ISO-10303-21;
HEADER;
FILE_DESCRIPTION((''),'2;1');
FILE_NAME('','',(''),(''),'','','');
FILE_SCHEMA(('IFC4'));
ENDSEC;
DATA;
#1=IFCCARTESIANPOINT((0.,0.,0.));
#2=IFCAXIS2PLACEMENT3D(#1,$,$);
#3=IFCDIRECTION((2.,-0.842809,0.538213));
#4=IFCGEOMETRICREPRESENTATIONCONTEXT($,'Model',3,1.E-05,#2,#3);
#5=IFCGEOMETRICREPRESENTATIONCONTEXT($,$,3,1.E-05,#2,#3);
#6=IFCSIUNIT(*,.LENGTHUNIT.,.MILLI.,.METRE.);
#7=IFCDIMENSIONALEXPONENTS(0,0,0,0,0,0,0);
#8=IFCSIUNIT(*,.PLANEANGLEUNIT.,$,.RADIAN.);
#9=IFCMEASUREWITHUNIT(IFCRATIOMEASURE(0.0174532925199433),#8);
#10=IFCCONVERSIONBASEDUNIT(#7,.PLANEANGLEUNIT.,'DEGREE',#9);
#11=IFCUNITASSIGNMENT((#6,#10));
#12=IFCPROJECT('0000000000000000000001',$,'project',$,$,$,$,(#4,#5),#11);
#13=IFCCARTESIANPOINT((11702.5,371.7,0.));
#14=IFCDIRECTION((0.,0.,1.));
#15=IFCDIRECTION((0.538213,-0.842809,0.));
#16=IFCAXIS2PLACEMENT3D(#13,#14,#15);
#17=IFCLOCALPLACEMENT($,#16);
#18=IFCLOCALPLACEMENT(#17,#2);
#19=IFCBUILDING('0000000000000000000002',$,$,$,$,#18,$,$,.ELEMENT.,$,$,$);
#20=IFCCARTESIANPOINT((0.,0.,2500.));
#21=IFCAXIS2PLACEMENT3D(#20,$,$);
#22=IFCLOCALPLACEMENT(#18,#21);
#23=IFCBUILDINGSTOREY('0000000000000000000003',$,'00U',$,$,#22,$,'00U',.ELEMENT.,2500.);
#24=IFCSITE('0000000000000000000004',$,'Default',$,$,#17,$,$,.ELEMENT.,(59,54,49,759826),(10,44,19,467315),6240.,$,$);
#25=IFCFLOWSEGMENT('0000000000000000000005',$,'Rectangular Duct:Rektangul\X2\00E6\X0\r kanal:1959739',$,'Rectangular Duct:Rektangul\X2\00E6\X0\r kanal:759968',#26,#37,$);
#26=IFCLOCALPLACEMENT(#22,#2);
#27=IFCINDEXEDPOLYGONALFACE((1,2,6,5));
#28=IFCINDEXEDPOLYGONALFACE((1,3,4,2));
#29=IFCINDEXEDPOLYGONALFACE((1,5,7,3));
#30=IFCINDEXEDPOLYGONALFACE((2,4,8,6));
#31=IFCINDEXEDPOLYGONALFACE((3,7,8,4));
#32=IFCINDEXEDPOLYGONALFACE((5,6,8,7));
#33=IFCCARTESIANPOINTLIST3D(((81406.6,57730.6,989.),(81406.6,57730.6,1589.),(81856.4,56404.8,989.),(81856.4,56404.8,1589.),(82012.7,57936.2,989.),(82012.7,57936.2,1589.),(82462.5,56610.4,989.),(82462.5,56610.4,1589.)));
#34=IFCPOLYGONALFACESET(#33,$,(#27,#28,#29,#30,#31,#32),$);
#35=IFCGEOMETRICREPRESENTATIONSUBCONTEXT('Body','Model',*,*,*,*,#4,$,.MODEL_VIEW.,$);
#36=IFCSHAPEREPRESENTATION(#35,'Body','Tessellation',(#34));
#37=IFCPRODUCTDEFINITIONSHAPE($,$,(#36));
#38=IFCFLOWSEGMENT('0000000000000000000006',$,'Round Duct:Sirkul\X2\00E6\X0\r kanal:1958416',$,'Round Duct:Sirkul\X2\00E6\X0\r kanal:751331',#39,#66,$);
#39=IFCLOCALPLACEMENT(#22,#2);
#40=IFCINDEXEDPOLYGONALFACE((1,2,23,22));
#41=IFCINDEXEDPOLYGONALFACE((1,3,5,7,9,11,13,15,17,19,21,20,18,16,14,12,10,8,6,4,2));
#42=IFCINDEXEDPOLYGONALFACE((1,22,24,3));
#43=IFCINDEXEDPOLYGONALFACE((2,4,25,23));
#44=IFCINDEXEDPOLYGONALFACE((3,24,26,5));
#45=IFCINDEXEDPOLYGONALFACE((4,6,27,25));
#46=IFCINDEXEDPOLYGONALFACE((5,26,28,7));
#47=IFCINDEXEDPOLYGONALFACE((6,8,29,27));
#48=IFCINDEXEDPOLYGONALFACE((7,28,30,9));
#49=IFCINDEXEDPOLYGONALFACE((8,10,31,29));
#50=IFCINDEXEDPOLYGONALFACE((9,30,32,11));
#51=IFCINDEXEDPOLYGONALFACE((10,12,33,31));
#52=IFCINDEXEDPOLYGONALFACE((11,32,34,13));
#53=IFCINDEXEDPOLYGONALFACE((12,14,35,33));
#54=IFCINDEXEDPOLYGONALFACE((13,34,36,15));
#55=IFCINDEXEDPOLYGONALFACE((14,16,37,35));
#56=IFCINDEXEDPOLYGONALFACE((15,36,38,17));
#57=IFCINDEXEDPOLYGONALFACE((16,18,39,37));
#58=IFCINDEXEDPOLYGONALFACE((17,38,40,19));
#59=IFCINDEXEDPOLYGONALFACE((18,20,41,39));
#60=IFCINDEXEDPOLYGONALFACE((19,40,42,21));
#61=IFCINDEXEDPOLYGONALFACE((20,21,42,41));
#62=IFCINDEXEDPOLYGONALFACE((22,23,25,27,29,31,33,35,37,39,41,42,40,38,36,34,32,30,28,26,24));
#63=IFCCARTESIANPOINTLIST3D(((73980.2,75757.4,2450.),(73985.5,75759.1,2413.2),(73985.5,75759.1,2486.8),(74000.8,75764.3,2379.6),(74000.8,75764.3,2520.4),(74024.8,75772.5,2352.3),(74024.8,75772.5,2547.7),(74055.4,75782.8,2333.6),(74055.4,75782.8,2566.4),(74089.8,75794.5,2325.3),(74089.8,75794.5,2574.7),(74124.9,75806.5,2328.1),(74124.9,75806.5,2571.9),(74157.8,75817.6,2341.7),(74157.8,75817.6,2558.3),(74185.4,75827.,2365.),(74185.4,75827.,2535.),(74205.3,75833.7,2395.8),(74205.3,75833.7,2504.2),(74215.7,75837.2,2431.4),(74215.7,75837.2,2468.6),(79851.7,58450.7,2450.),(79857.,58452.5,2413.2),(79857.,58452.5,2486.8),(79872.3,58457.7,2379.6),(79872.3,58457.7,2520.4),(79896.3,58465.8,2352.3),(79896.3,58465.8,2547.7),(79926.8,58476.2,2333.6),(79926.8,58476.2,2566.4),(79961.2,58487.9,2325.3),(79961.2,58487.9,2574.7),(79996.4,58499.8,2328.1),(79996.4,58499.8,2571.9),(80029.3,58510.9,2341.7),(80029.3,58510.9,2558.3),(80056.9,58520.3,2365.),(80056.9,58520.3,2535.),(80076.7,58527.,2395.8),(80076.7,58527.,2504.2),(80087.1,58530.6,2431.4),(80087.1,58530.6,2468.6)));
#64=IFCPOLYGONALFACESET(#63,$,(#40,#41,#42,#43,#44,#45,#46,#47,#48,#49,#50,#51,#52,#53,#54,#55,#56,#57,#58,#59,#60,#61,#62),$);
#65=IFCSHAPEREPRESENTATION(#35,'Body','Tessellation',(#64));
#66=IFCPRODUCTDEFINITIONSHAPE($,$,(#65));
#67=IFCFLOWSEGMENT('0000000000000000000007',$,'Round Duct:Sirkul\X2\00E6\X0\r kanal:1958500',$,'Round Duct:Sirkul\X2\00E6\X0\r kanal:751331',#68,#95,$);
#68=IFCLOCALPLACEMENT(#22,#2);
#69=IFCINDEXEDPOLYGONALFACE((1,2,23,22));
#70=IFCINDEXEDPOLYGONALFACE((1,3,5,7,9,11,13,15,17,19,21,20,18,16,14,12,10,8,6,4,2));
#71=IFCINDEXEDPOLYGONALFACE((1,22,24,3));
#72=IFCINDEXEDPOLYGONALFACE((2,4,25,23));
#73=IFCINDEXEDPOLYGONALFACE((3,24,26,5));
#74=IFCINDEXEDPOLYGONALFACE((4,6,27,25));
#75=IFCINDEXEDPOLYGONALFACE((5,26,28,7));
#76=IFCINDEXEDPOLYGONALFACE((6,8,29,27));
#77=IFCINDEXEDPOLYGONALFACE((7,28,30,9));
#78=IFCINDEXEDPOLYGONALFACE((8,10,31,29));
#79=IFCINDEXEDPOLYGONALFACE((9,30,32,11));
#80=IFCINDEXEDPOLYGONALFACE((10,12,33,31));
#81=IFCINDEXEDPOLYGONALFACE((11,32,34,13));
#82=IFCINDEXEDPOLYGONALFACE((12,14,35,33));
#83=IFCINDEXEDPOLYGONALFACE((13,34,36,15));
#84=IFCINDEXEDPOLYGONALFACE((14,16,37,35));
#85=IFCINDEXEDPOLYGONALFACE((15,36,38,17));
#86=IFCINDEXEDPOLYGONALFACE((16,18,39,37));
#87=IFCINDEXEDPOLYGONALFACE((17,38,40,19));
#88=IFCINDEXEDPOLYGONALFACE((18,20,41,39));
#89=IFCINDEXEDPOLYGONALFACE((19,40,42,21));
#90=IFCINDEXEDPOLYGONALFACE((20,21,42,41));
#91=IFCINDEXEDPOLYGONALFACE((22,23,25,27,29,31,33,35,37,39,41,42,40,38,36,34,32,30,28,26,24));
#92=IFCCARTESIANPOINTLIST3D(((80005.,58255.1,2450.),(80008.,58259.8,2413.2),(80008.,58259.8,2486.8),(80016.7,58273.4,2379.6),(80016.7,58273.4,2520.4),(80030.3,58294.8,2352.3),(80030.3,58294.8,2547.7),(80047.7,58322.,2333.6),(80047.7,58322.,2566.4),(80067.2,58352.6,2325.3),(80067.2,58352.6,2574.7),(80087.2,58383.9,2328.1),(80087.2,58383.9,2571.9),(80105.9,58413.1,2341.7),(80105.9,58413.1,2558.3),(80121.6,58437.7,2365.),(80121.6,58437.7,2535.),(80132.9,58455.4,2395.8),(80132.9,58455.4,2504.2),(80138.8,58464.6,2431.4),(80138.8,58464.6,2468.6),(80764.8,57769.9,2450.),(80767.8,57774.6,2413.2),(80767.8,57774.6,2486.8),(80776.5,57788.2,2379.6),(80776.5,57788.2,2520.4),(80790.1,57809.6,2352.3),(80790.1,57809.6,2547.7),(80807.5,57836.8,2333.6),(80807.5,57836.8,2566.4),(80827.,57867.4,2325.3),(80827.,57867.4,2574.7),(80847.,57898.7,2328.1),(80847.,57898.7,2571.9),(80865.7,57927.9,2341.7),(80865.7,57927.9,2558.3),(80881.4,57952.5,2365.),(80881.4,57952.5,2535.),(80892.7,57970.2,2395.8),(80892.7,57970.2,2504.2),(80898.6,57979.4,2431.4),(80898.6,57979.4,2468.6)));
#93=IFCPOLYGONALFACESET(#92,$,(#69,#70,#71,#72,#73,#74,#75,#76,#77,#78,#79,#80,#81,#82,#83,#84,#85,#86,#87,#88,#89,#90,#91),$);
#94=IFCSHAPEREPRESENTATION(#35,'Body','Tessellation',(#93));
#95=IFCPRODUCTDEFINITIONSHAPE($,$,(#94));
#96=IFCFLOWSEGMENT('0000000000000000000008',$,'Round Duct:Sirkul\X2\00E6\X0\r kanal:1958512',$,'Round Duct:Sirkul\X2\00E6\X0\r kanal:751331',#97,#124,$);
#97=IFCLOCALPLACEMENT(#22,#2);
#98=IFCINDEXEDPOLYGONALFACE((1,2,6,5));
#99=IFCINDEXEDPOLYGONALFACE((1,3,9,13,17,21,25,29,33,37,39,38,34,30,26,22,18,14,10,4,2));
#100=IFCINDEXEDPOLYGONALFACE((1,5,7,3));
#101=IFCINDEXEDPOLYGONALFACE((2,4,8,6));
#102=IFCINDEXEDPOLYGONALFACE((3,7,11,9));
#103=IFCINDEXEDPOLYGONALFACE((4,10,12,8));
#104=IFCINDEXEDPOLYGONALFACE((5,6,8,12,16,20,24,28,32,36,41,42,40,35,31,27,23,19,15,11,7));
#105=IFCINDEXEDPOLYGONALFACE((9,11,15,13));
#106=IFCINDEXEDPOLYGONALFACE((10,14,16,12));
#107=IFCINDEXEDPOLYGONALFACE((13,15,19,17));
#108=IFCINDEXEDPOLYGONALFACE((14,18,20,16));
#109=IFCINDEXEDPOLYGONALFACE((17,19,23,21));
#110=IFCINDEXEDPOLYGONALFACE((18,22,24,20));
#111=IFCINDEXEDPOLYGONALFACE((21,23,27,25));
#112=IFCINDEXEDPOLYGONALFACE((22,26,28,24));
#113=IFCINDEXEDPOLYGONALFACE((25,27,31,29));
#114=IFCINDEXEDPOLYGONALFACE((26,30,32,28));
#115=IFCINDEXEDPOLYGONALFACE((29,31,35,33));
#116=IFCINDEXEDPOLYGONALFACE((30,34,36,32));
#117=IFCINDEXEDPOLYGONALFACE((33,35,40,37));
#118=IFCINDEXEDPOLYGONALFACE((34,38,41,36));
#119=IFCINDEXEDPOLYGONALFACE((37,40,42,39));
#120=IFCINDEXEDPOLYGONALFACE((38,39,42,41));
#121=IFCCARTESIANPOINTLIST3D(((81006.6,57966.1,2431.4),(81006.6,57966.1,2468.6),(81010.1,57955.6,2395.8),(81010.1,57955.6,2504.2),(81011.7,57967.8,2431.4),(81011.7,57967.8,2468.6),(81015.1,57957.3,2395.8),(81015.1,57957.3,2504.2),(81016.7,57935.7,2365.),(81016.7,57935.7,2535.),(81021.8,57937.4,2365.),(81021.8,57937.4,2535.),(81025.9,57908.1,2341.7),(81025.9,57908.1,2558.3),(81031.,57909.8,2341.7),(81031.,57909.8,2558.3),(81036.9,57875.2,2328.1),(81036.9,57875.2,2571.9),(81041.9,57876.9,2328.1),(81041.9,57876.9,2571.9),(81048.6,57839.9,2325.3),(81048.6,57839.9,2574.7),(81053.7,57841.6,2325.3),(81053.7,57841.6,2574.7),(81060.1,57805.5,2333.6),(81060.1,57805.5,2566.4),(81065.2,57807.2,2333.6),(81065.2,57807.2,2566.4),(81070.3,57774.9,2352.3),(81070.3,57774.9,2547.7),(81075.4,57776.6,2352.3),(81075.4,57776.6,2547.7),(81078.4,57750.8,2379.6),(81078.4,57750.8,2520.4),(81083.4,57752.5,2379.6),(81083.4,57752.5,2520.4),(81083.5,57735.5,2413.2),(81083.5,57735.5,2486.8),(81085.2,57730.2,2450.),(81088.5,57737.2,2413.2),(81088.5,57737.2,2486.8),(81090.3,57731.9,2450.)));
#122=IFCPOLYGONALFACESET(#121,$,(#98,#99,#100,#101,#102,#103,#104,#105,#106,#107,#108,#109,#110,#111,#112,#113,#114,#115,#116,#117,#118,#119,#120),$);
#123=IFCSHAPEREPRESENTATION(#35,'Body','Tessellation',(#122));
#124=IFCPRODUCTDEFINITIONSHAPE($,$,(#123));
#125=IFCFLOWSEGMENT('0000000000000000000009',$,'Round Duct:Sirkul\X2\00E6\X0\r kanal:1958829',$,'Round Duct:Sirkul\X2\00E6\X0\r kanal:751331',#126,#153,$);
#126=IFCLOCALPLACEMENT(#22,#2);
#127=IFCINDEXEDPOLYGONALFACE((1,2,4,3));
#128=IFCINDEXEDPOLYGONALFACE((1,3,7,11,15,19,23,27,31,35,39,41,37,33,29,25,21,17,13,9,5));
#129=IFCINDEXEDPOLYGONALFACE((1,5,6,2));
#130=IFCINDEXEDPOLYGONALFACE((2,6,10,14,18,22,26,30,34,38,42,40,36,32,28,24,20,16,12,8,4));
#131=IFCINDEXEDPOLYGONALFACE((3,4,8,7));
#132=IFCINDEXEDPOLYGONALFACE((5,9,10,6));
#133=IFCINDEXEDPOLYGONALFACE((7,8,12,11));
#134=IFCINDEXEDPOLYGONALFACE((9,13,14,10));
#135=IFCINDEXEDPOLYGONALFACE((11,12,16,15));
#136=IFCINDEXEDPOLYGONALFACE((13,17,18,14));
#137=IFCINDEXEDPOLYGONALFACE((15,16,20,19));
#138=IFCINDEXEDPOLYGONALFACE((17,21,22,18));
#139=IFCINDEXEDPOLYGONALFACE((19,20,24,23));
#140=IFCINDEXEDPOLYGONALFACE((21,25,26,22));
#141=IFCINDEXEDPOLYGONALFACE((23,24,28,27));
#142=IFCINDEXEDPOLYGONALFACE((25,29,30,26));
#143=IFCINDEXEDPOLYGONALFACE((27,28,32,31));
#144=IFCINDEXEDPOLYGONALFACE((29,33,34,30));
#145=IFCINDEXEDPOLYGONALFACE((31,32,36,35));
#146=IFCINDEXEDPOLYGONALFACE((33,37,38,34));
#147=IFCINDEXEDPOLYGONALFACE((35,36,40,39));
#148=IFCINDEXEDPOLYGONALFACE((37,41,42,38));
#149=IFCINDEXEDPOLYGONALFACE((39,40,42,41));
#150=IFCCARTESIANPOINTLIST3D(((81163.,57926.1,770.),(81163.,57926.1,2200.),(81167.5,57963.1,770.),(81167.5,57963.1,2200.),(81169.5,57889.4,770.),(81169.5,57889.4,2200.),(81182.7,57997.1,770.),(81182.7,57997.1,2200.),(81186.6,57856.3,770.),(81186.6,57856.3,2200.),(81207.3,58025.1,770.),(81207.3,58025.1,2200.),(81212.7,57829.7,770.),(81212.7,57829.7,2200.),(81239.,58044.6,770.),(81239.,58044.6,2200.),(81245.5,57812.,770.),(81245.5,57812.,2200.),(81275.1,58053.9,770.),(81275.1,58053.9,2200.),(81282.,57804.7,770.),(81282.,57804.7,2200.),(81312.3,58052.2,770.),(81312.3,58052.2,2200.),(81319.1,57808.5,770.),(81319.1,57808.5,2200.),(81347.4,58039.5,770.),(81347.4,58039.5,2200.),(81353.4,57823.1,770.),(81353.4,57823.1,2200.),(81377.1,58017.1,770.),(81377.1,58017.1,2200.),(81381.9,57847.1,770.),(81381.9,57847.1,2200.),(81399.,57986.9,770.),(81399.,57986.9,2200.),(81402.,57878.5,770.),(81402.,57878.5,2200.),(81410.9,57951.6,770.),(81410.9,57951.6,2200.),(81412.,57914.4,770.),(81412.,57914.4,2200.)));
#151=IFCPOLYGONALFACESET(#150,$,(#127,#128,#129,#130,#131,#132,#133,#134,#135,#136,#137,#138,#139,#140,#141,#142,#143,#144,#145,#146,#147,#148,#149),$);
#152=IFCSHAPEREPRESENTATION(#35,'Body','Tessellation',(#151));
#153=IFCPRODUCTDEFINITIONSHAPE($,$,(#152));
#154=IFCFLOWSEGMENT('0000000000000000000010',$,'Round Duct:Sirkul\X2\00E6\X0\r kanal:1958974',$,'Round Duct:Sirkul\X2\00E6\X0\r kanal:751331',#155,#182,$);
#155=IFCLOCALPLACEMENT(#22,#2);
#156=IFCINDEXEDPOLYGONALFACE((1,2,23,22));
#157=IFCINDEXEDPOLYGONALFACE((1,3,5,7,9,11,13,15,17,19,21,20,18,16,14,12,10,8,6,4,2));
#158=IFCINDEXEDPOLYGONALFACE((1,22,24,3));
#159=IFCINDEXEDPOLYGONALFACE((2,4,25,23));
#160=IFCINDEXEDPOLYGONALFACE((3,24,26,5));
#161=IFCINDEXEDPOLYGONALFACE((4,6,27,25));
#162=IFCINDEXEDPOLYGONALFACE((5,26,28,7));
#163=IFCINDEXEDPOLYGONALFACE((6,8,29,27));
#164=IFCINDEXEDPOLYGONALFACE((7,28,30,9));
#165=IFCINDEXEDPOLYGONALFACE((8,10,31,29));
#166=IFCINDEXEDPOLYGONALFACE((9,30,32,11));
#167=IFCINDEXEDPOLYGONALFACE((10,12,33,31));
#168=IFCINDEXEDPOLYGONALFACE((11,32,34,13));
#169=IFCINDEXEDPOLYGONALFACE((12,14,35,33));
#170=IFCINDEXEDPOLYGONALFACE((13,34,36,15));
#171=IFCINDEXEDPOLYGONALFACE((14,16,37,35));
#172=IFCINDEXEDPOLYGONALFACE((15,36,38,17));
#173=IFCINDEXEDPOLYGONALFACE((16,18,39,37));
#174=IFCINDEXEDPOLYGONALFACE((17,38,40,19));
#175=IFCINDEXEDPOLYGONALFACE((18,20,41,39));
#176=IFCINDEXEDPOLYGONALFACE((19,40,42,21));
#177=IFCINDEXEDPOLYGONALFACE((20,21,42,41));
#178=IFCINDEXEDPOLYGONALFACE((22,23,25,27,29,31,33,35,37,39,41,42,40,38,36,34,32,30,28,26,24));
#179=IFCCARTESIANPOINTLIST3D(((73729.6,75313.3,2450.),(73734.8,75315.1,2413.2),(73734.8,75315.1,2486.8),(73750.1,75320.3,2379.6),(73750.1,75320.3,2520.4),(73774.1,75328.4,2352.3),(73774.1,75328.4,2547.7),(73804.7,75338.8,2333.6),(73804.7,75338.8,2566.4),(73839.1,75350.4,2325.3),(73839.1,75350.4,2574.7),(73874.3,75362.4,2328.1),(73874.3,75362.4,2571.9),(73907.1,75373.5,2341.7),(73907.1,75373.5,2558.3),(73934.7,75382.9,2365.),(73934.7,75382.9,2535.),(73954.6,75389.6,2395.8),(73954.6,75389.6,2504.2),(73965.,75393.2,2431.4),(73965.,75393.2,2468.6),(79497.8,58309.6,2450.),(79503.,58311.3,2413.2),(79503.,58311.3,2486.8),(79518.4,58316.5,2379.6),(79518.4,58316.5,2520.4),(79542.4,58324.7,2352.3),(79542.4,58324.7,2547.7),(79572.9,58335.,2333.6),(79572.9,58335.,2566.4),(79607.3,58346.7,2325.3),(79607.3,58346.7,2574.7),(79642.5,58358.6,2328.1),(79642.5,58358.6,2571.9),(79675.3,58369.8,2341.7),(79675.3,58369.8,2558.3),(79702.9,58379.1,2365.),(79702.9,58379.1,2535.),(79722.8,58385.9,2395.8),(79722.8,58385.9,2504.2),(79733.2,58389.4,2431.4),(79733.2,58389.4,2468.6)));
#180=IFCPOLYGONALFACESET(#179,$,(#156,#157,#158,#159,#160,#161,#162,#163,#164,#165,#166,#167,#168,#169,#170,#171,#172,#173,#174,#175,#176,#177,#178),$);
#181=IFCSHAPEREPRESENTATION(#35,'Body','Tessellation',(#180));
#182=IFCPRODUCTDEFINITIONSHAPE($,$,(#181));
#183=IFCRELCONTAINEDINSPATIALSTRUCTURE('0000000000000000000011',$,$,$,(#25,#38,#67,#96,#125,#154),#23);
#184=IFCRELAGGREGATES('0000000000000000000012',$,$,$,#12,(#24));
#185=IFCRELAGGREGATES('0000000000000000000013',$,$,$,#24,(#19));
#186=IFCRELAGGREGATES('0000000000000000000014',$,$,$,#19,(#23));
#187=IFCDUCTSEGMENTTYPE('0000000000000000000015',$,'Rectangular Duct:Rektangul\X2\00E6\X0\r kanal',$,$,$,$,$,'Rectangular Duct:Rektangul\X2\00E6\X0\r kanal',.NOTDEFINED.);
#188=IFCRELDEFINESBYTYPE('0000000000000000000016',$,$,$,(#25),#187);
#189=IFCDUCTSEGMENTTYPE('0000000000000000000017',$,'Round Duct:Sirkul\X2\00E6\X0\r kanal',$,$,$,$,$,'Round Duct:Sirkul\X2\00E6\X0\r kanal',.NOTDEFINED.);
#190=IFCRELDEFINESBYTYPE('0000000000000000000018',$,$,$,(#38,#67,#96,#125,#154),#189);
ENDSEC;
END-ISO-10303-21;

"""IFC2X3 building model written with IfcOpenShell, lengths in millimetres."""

from ifc_helpers import new_model, entity, si_unit, converted_unit, direction, frame, frame_2d, origin, origin_2d_with_axis, place, context, subcontext, project, spatial, rectangle, circle, extrude, type_object, element, save


model = new_model("IFC2X3")

# Units and contexts
model_context = context("Model", 3, precision=1e-05, world=origin(), true_north=direction((2.0, -0.842809, 0.538213)))
context_of_model = context(None, 3, precision=1e-05, world=origin(), true_north=direction((2.0, -0.842809, 0.538213)))
body_context = subcontext(model_context, "Body", "Model", "MODEL_VIEW")
ifc_project = project(units=[si_unit("LENGTHUNIT", "METRE", prefix="MILLI"), converted_unit("PLANEANGLEUNIT", "DEGREE", entity("IfcRatioMeasure", 0.0174532925199433), si_unit("PLANEANGLEUNIT", "RADIAN"), dimensions=[0, 0, 0, 0, 0, 0, 0])], contexts=[model_context, context_of_model])

# Site, building, storey
site_placement = place(None, frame((11702.5, 371.7, 0.0), z_axis=(0.0, 0.0, 1.0), x_axis=(0.538213, -0.842809, 0.0)))
site = spatial("IfcSite", under=ifc_project, at=site_placement, Name="Default", CompositionType="ELEMENT", RefLatitude=(59, 54, 49, 759826), RefLongitude=(10, 44, 19, 467315), RefElevation=6240.0)
building_placement = place(site_placement, origin())
building = spatial("IfcBuilding", under=site, at=building_placement, CompositionType="ELEMENT")
storey_placement = place(building_placement, frame((0.0, 0.0, 2500.0)))
storey = spatial("IfcBuildingStorey", under=building, at=storey_placement, Name="00U", LongName="00U", CompositionType="ELEMENT", Elevation=2500.0)

# Flow segments
duct_segment_type_1 = type_object("IfcDuctSegmentType", Name="Rectangular Duct:Rektangulær kanal", ElementType="Rectangular Duct:Rektangulær kanal", PredefinedType="NOTDEFINED")
flow_segment_1_placement = place(storey_placement, origin())
element("IfcFlowSegment", 1, at=flow_segment_1_placement, inside=storey, type_object=duct_segment_type_1, Name="Rectangular Duct:Rektangulær kanal:1959739", ObjectType="Rectangular Duct:Rektangulær kanal:759968", context=body_context, shape_type="SweptSolid", body=[
    extrude(rectangle(XDim=640.0, YDim=1400.0, at=frame_2d((0.0, 0.0), x_axis=(1.0, 0.0))), frame((81934.6, 57170.5, 989.0), z_axis=(0.0, 0.0, 1.0), x_axis=(-0.94698, -0.321291, 0.0)), (0.0, 0.0, 1.0), 600.0),
])
duct_segment_type_2 = type_object("IfcDuctSegmentType", Name="Round Duct:Sirkulær kanal", ElementType="Round Duct:Sirkulær kanal", PredefinedType="NOTDEFINED")
flow_segment_2_placement = place(storey_placement, origin())
element("IfcFlowSegment", 2, at=flow_segment_2_placement, inside=storey, type_object=duct_segment_type_2, Name="Round Duct:Sirkulær kanal:1958416", ObjectType="Round Duct:Sirkulær kanal:751331", context=body_context, shape_type="SweptSolid", body=[
    extrude(circle(Radius=125.0, at=origin_2d_with_axis()), frame((74098.6, 75797.5, 2450.0), z_axis=(0.321276, -0.946986, 0.0), x_axis=(-0.946986, -0.321276, 0.0)), (0.0, 0.0, 1.0), 18275.5),
])
flow_segment_3_placement = place(storey_placement, origin())
element("IfcFlowSegment", 3, at=flow_segment_3_placement, inside=storey, type_object=duct_segment_type_2, Name="Round Duct:Sirkulær kanal:1958500", ObjectType="Round Duct:Sirkulær kanal:751331", context=body_context, shape_type="SweptSolid", body=[
    extrude(circle(Radius=125.0, at=origin_2d_with_axis()), frame((80072.3, 58360.5, 2450.0), z_axis=(0.842809, -0.538213, 0.0), x_axis=(-0.538213, -0.842809, 0.0)), (0.0, 0.0, 1.0), 901.5),
])
flow_segment_4_placement = place(storey_placement, origin())
element("IfcFlowSegment", 4, at=flow_segment_4_placement, inside=storey, type_object=duct_segment_type_2, Name="Round Duct:Sirkulær kanal:1958512", ObjectType="Round Duct:Sirkulær kanal:751331", context=body_context, shape_type="SweptSolid", body=[
    extrude(circle(Radius=125.0, at=origin_2d_with_axis()), frame((81045.7, 57848.8, 2450.0), z_axis=(0.948667, 0.316277, 0.0), x_axis=(0.316277, -0.948667, 0.0)), (0.0, 0.0, 1.0), 5.3),
])
flow_segment_5_placement = place(storey_placement, origin())
element("IfcFlowSegment", 5, at=flow_segment_5_placement, inside=storey, type_object=duct_segment_type_2, Name="Round Duct:Sirkulær kanal:1958829", ObjectType="Round Duct:Sirkulær kanal:751331", context=body_context, shape_type="SweptSolid", body=[
    extrude(circle(Radius=125.0, at=frame_2d((0.0, 0.0), x_axis=(1.0, 0.0))), frame((81287.9, 57929.6, 770.0), z_axis=(0.0, 0.0, 1.0), x_axis=(-0.946996, -0.321246, 0.0)), (0.0, 0.0, 1.0), 1430.0),
])
flow_segment_6_placement = place(storey_placement, origin())
element("IfcFlowSegment", 6, at=flow_segment_6_placement, inside=storey, type_object=duct_segment_type_2, Name="Round Duct:Sirkulær kanal:1958974", ObjectType="Round Duct:Sirkulær kanal:751331", context=body_context, shape_type="SweptSolid", body=[
    extrude(circle(Radius=125.0, at=origin_2d_with_axis()), frame((79616.2, 58349.7, 2450.0), z_axis=(-0.321251, 0.946994, 0.0), x_axis=(-0.946994, -0.321251, 0.0)), (0.0, 0.0, 1.0), 17955.5),
])

save(model, "model.ifc")
